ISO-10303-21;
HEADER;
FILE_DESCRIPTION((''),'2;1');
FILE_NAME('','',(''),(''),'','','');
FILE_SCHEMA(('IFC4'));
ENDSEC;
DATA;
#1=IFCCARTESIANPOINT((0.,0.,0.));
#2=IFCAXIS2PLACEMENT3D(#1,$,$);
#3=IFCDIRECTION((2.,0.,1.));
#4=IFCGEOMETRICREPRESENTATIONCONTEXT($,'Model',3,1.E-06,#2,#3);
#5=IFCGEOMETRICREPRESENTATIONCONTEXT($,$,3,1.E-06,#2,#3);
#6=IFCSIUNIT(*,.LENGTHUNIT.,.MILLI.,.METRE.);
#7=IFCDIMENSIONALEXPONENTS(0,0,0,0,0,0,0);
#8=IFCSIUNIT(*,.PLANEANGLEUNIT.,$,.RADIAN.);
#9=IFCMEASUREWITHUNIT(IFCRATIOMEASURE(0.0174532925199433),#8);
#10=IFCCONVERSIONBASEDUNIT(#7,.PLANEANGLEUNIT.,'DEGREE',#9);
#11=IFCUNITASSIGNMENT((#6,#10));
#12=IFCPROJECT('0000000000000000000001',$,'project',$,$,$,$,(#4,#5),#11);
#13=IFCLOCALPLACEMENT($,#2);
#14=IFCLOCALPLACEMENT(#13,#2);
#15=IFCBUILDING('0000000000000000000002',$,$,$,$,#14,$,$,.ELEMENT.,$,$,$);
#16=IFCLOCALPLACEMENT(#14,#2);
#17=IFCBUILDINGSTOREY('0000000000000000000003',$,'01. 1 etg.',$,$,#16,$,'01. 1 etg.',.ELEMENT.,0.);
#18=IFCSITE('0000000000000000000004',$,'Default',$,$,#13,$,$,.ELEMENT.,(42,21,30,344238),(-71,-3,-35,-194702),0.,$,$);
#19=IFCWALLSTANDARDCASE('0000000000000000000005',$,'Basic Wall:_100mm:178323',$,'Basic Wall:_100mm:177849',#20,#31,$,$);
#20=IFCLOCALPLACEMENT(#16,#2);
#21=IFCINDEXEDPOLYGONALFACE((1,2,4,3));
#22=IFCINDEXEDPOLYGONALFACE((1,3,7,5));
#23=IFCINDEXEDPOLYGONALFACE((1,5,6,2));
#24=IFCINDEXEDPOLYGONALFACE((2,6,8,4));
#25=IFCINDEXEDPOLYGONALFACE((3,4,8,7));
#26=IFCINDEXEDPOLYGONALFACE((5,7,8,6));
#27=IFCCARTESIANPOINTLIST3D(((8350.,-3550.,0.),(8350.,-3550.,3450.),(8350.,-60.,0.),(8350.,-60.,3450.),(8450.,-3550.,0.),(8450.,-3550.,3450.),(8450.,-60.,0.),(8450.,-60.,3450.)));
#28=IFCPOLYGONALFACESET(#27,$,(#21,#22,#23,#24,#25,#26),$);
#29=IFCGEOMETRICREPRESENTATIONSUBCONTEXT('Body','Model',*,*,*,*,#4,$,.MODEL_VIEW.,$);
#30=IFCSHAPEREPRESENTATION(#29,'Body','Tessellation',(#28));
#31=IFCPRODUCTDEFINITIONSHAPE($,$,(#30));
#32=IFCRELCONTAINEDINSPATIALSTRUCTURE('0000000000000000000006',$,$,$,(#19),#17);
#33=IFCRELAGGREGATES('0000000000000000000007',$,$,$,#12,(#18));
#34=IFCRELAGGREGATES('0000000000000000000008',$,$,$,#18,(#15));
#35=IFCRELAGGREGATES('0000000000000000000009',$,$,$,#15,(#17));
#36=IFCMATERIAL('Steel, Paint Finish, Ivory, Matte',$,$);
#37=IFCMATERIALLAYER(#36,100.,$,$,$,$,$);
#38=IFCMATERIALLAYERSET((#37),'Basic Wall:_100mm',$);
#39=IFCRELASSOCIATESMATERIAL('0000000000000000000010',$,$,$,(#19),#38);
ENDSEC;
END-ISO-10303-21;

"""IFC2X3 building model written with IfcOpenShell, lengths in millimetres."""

from ifc_helpers import new_model, entity, si_unit, converted_unit, direction, frame, frame_2d, origin, place, context, subcontext, project, spatial, polyline, rectangle, extrude, clip, bounded_halfspace, material, layer, layer_set, layer_usage, element, save


model = new_model("IFC2X3")

# Units and contexts
model_context = context("Model", 3, precision=1e-06, world=origin(), true_north=direction((2.0, 0.0, 1.0)))
context_of_model = context(None, 3, precision=1e-06, world=origin(), true_north=direction((2.0, 0.0, 1.0)))
body_context = subcontext(model_context, "Body", "Model", "MODEL_VIEW")
ifc_project = project(units=[si_unit("LENGTHUNIT", "METRE", prefix="MILLI"), converted_unit("PLANEANGLEUNIT", "DEGREE", entity("IfcRatioMeasure", 0.0174532925199433), si_unit("PLANEANGLEUNIT", "RADIAN"), dimensions=[0, 0, 0, 0, 0, 0, 0])], contexts=[model_context, context_of_model])

# Site, building, storey
site_placement = place(None, origin())
site = spatial("IfcSite", under=ifc_project, at=site_placement, Name="Default", CompositionType="ELEMENT", RefLatitude=(42, 21, 30, 344238), RefLongitude=(-71, -3, -35, -194702), RefElevation=0.0)
building_placement = place(site_placement, origin())
building = spatial("IfcBuilding", under=site, at=building_placement, CompositionType="ELEMENT")
storey_placement = place(building_placement, origin())
storey = spatial("IfcBuildingStorey", under=building, at=storey_placement, Name="01. 1 etg.", LongName="01. 1 etg.", CompositionType="ELEMENT", Elevation=0.0)

# Shared definitions
ifc_material_1 = material(Name="Steel, Paint Finish, Ivory, Matte")
ifc_layer_1 = layer(ifc_material_1, 100.0)
ifc_layer_set_1 = layer_set([ifc_layer_1], Name="Basic Wall:_100mm")

# Wall
ifc_layer_usage_1 = layer_usage(ifc_layer_set_1, "AXIS2", "NEGATIVE", 50.0)
wall_1_placement = place(storey_placement, frame((8400.0, -3550.0, 0.0), z_axis=(0.0, 0.0, 1.0), x_axis=(0.0, 1.0, 0.0)))
element("IfcWallStandardCase", 1, at=wall_1_placement, inside=storey, material=ifc_layer_usage_1, Name="Basic Wall:_100mm:178323", ObjectType="Basic Wall:_100mm:177849", context=body_context, shape_type="Clipping", body=[
    clip(extrude(rectangle(XDim=3490.0, YDim=100.0, at=frame_2d((1745.0, 0.0), x_axis=(-1.0, 0.0))), origin(), (0.0, 0.0, 1.0), 3450.0), bounded_halfspace(frame((0.0, -50.0, 3450.0), z_axis=(0.0, 0.0, -1.0), x_axis=(-1.0, 0.0, 0.0)), True, frame((0.0, -50.0, 3450.0)), polyline([(0.0, 0.0), (3490.0, 0.0), (3490.0, 100.0), (0.0, 100.0), (0.0, 0.0)]))),
])

save(model, "model.ifc")
